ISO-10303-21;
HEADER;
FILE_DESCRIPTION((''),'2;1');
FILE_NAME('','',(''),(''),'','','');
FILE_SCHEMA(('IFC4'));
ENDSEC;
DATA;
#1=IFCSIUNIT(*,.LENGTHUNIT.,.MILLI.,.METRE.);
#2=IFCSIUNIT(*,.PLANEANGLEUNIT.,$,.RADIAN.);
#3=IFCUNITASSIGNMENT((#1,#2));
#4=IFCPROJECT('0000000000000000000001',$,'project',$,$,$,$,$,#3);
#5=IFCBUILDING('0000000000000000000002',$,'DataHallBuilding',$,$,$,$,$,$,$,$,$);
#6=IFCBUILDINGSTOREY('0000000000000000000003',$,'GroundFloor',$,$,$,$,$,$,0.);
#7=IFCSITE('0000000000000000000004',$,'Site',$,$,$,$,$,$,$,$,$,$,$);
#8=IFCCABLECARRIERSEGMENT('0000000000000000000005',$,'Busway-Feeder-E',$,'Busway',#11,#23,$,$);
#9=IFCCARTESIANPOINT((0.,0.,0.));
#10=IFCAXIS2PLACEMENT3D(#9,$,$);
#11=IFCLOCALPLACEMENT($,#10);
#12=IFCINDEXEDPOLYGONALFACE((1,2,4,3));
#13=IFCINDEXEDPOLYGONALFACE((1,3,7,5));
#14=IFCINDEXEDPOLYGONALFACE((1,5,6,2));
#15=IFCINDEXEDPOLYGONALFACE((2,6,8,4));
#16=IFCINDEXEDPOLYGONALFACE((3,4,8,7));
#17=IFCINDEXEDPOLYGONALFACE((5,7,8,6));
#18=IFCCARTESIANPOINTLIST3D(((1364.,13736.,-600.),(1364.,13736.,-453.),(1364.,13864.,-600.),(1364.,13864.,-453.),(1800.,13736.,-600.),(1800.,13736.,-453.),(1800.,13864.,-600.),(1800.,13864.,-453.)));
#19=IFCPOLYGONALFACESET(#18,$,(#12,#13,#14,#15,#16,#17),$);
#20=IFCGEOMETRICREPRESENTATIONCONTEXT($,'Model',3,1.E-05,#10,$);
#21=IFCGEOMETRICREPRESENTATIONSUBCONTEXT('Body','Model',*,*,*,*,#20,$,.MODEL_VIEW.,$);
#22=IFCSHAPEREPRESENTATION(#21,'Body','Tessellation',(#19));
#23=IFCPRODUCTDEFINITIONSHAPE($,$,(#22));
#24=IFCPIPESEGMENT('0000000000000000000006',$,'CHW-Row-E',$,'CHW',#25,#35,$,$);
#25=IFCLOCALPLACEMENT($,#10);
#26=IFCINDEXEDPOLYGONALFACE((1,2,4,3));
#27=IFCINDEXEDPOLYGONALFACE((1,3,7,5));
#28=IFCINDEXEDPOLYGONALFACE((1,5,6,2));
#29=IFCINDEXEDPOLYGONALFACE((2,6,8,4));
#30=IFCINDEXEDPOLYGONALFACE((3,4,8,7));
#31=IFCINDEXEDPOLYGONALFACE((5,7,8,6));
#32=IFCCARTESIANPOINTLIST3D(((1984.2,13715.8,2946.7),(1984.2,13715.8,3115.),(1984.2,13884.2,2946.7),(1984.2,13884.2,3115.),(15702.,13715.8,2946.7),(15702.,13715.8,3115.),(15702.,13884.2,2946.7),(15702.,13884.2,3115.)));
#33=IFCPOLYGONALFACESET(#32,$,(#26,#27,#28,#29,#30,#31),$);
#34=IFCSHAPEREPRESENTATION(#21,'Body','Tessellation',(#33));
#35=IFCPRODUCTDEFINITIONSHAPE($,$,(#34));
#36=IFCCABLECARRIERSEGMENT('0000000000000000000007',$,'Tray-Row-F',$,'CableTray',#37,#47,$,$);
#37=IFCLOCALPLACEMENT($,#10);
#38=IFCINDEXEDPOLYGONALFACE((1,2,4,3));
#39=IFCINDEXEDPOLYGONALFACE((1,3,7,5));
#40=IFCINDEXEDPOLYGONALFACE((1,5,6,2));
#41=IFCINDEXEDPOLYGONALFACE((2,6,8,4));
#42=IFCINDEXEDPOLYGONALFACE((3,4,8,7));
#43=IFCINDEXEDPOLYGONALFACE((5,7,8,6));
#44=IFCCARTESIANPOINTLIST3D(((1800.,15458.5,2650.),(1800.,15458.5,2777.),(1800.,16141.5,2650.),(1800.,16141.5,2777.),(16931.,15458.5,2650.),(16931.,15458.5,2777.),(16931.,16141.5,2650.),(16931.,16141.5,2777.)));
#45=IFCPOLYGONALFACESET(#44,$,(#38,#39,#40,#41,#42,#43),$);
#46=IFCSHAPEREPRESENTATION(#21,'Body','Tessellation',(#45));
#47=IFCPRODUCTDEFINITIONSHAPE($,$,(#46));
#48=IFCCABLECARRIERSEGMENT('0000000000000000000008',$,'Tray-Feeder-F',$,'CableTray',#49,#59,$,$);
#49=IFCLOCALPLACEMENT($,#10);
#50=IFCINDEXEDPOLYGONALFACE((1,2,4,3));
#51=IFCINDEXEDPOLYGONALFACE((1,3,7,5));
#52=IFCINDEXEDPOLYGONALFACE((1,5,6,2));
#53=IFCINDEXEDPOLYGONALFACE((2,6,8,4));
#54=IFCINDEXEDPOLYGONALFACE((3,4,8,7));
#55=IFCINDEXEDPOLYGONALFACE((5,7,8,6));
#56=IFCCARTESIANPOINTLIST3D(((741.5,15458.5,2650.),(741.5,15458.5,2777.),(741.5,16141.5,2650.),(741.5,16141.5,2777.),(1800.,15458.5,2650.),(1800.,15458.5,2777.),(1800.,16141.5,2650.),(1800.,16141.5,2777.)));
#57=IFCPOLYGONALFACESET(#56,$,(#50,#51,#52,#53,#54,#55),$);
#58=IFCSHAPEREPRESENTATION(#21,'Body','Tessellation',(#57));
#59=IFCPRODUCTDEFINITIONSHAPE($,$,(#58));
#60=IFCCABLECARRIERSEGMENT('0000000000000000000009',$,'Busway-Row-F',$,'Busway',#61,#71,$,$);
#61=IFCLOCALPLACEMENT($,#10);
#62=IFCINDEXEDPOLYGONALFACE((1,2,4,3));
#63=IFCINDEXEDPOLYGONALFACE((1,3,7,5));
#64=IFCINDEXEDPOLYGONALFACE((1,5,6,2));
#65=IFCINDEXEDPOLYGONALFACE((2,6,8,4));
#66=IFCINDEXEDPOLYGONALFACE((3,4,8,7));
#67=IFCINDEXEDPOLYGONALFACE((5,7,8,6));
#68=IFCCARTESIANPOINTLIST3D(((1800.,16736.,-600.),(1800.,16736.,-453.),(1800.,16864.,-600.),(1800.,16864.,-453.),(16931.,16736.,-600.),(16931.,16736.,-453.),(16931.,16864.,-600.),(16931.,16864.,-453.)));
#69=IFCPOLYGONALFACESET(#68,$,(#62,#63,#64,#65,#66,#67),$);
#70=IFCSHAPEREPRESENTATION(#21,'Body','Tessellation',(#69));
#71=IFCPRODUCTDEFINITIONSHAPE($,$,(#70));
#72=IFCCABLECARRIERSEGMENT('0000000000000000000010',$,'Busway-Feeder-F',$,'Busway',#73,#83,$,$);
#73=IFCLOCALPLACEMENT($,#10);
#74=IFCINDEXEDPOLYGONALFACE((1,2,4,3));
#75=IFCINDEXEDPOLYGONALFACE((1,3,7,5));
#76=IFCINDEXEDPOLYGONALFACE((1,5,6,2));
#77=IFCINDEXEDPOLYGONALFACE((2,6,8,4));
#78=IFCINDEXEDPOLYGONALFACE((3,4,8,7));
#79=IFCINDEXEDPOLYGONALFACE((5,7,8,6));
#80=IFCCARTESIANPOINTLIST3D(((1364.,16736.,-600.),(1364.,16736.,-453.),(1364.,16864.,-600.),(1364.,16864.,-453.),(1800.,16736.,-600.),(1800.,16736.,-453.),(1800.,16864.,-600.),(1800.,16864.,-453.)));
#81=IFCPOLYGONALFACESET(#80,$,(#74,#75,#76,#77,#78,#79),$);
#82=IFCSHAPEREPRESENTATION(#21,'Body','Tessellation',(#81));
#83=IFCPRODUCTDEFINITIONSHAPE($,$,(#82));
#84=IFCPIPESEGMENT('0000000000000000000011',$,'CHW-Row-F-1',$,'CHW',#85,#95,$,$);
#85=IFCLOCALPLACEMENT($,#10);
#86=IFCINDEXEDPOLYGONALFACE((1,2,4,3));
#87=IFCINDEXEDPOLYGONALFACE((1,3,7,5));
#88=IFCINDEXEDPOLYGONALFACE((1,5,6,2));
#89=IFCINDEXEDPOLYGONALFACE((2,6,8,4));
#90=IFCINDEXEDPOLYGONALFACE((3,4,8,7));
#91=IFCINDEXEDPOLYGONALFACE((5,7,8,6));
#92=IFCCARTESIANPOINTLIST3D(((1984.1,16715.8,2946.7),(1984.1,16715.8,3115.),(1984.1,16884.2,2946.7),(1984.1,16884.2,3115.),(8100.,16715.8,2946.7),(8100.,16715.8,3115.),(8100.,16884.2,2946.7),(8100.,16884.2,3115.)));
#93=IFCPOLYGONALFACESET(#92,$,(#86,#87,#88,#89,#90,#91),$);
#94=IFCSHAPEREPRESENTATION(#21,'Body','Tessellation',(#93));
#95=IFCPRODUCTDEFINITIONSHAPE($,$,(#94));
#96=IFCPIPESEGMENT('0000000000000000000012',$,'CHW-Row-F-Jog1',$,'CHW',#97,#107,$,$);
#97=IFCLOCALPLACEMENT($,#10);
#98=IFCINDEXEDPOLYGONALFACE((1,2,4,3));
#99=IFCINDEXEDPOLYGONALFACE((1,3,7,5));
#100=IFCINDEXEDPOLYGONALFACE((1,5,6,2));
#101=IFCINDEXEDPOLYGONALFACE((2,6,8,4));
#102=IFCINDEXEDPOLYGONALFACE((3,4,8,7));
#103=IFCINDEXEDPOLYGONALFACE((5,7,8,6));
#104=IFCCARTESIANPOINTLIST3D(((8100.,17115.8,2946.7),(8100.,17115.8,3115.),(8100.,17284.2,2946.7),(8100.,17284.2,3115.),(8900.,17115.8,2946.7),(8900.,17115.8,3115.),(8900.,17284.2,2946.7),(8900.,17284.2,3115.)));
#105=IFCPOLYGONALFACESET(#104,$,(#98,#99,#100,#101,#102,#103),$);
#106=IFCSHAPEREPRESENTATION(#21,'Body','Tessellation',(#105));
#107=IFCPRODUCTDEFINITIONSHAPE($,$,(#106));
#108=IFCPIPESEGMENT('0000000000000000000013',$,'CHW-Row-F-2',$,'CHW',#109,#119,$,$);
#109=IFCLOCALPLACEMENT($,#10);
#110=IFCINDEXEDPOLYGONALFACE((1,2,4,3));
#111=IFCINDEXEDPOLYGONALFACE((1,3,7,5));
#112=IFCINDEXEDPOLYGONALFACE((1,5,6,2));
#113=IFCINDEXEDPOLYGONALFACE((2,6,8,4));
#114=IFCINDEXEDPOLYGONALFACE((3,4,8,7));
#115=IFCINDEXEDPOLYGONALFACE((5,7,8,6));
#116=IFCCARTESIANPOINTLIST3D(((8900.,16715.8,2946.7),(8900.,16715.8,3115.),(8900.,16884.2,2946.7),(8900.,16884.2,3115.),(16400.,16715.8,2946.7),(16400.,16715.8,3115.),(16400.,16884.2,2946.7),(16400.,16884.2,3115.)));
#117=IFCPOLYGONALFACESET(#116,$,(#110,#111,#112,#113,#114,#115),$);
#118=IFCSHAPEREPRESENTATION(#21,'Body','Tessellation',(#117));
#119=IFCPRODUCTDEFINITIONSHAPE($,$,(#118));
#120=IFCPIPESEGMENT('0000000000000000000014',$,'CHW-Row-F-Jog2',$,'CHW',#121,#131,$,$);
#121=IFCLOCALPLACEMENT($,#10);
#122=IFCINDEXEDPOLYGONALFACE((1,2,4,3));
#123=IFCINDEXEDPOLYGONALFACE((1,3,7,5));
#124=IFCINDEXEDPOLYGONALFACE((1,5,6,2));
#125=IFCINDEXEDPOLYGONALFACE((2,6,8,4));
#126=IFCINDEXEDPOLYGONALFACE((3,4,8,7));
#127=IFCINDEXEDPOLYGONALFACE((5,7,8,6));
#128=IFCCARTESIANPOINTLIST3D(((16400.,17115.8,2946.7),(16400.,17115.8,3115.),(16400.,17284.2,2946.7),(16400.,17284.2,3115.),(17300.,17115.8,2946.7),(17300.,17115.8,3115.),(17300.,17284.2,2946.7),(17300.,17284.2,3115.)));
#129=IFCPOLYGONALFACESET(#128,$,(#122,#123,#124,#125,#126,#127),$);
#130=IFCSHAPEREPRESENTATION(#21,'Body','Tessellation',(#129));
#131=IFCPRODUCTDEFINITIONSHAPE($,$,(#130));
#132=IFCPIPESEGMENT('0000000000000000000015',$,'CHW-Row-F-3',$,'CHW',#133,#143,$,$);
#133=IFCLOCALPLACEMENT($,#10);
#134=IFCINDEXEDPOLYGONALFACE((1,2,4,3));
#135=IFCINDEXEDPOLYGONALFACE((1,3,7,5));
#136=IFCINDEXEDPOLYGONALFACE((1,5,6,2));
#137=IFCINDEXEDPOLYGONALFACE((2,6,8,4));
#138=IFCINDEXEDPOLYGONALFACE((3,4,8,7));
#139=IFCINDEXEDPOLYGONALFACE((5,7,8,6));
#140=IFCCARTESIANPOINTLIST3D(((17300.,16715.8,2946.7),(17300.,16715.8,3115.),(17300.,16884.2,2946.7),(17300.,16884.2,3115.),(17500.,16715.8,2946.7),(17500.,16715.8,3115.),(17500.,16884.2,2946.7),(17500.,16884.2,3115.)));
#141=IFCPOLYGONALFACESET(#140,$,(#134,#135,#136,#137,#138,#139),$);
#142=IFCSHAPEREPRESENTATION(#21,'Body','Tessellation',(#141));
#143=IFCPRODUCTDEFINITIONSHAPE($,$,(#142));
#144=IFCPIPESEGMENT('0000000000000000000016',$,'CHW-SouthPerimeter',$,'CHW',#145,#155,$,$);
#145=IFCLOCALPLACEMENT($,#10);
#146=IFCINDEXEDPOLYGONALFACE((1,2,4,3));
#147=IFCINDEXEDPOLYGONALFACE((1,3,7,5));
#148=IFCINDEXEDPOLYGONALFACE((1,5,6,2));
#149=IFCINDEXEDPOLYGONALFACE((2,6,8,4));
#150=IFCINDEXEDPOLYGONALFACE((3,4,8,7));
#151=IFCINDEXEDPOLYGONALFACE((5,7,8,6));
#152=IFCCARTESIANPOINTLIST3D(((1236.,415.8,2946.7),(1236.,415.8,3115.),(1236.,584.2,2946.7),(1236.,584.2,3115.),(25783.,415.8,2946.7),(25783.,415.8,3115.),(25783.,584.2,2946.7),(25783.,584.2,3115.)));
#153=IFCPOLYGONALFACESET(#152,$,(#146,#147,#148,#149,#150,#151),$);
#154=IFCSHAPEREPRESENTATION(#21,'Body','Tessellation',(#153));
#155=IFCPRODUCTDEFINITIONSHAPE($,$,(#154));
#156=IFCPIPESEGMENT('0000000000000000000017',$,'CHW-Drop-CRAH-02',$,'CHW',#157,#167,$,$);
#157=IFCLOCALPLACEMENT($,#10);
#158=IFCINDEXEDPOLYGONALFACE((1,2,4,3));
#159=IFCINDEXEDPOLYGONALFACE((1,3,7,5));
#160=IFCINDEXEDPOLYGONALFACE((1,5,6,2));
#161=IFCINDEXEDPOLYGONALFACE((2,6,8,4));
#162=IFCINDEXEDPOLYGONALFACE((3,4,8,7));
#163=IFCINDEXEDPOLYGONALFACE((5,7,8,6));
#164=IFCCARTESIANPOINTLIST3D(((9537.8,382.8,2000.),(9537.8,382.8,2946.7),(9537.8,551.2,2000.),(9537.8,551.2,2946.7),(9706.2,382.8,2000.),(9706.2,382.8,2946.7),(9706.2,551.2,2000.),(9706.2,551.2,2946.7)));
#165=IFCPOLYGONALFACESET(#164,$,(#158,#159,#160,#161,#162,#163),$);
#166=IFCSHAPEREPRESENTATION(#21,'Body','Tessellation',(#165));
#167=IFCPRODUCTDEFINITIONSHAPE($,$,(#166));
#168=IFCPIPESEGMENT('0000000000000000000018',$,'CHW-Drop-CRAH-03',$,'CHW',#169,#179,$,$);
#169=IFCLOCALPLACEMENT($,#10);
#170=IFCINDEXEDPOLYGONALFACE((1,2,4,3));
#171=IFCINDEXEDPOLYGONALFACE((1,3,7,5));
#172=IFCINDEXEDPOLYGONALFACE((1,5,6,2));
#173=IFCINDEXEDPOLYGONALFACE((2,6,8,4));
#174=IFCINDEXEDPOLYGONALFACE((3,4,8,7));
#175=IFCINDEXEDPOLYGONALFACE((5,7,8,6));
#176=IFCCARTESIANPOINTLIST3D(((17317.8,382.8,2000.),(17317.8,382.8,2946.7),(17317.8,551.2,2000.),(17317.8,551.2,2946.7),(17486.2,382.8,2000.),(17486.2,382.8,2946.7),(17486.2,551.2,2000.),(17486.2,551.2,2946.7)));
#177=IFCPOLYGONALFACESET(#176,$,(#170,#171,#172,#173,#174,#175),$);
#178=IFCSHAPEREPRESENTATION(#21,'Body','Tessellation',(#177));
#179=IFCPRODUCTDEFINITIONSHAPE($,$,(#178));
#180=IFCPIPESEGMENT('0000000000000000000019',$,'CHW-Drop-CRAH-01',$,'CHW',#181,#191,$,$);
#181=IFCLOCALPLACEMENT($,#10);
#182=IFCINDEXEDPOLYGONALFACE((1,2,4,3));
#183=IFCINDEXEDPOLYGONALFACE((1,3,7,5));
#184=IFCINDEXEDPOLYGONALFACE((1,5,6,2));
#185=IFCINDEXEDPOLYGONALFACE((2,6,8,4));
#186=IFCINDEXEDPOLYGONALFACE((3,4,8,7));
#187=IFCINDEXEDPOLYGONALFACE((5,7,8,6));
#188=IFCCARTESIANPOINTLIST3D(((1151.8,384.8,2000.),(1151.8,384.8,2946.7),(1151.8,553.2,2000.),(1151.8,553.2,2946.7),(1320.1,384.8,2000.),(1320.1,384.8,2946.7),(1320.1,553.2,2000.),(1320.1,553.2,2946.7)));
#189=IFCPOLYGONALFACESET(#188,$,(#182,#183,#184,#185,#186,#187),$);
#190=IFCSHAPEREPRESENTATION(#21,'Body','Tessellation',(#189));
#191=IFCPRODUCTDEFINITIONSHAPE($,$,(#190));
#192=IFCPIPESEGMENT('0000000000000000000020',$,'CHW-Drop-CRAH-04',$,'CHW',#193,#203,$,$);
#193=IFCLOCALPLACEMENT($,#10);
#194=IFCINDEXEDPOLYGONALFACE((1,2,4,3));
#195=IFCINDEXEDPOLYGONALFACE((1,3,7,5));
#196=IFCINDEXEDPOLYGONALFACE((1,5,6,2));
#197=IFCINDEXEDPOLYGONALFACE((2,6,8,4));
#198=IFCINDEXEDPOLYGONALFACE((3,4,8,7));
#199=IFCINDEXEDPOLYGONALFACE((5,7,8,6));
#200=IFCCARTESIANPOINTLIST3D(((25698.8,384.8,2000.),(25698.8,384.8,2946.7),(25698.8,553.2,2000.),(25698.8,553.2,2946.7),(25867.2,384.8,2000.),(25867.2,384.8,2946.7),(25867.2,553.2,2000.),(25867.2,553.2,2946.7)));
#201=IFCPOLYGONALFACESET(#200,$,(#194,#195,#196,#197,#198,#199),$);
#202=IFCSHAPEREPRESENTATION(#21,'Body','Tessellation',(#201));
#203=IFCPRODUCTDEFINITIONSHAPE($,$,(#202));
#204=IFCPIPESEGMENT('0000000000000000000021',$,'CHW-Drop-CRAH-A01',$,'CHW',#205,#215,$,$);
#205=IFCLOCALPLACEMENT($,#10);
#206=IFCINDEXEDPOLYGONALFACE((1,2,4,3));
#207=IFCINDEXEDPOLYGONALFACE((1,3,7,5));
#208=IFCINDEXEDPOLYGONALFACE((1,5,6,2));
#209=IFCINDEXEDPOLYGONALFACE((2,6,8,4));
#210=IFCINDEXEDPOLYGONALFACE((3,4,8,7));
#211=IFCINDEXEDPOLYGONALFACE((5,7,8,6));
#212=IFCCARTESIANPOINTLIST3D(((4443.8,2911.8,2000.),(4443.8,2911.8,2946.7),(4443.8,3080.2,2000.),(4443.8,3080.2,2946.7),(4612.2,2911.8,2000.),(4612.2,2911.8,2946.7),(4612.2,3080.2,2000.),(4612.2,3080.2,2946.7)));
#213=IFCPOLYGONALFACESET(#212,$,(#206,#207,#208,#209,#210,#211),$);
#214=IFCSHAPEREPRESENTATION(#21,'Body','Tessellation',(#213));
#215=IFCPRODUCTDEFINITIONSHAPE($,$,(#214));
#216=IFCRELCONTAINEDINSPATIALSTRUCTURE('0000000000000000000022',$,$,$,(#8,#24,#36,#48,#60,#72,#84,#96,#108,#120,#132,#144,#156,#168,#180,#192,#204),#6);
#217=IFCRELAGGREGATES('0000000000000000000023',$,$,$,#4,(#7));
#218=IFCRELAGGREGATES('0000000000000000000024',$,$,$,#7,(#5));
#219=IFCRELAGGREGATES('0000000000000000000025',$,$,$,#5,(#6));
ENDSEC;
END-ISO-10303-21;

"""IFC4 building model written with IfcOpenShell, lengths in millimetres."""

from ifc_helpers import new_model, si_unit, frame, origin, place, context, subcontext, project, spatial, rectangle, extrude, element, save


model = new_model("IFC4")

# Units and contexts
model_context = context("Model", 3, precision=1e-05, world=origin())
body_context = subcontext(model_context, "Body", "Model", "MODEL_VIEW")
ifc_project = project(units=[si_unit("LENGTHUNIT", "METRE", prefix="MILLI"), si_unit("PLANEANGLEUNIT", "RADIAN")])

# Site, building, storey
site = spatial("IfcSite", under=ifc_project, Name="Site")
building = spatial("IfcBuilding", under=site, Name="DataHallBuilding")
storey = spatial("IfcBuildingStorey", under=building, Name="GroundFloor", Elevation=0.0)

# Cable carrier segment
cable_carrier_segment_1_placement = place(None, origin())
element("IfcCableCarrierSegment", 1, at=cable_carrier_segment_1_placement, inside=storey, Name="Busway-Feeder-E", ObjectType="Busway", context=body_context, shape_type="SweptSolid", body=[
    extrude(rectangle(XDim=436.0, YDim=128.0), frame((1582.0, 13800.0, -600.0), z_axis=(0.0, 0.0, 1.0), x_axis=(1.0, 0.0, 0.0)), (0.0, 0.0, 1.0), 147.0),
])

# Pipe segment
pipe_segment_1_placement = place(None, origin())
element("IfcPipeSegment", 2, at=pipe_segment_1_placement, inside=storey, Name="CHW-Row-E", ObjectType="CHW", context=body_context, shape_type="SweptSolid", body=[
    extrude(rectangle(XDim=13717.9, YDim=168.3), frame((8843.1, 13800.0, 2946.7), z_axis=(0.0, 0.0, 1.0), x_axis=(1.0, 0.0, 0.0)), (0.0, 0.0, 1.0), 168.3),
])

# Cable carrier segments
cable_carrier_segment_2_placement = place(None, origin())
element("IfcCableCarrierSegment", 3, at=cable_carrier_segment_2_placement, inside=storey, Name="Tray-Row-F", ObjectType="CableTray", context=body_context, shape_type="SweptSolid", body=[
    extrude(rectangle(XDim=15131.0, YDim=683.0), frame((9365.5, 15800.0, 2650.0), z_axis=(0.0, 0.0, 1.0), x_axis=(1.0, 0.0, 0.0)), (0.0, 0.0, 1.0), 127.0),
])
cable_carrier_segment_3_placement = place(None, origin())
element("IfcCableCarrierSegment", 4, at=cable_carrier_segment_3_placement, inside=storey, Name="Tray-Feeder-F", ObjectType="CableTray", context=body_context, shape_type="SweptSolid", body=[
    extrude(rectangle(XDim=1058.5, YDim=683.0), frame((1270.8, 15800.0, 2650.0), z_axis=(0.0, 0.0, 1.0), x_axis=(1.0, 0.0, 0.0)), (0.0, 0.0, 1.0), 127.0),
])
cable_carrier_segment_4_placement = place(None, origin())
element("IfcCableCarrierSegment", 5, at=cable_carrier_segment_4_placement, inside=storey, Name="Busway-Row-F", ObjectType="Busway", context=body_context, shape_type="SweptSolid", body=[
    extrude(rectangle(XDim=15131.0, YDim=128.0), frame((9365.5, 16800.0, -600.0), z_axis=(0.0, 0.0, 1.0), x_axis=(1.0, 0.0, 0.0)), (0.0, 0.0, 1.0), 147.0),
])
cable_carrier_segment_5_placement = place(None, origin())
element("IfcCableCarrierSegment", 6, at=cable_carrier_segment_5_placement, inside=storey, Name="Busway-Feeder-F", ObjectType="Busway", context=body_context, shape_type="SweptSolid", body=[
    extrude(rectangle(XDim=436.0, YDim=128.0), frame((1582.0, 16800.0, -600.0), z_axis=(0.0, 0.0, 1.0), x_axis=(1.0, 0.0, 0.0)), (0.0, 0.0, 1.0), 147.0),
])

# Pipe segments
pipe_segment_2_placement = place(None, origin())
element("IfcPipeSegment", 7, at=pipe_segment_2_placement, inside=storey, Name="CHW-Row-F-1", ObjectType="CHW", context=body_context, shape_type="SweptSolid", body=[
    extrude(rectangle(XDim=6115.9, YDim=168.3), frame((5042.1, 16800.0, 2946.7), z_axis=(0.0, 0.0, 1.0), x_axis=(1.0, 0.0, 0.0)), (0.0, 0.0, 1.0), 168.3),
])
pipe_segment_3_placement = place(None, origin())
element("IfcPipeSegment", 8, at=pipe_segment_3_placement, inside=storey, Name="CHW-Row-F-Jog1", ObjectType="CHW", context=body_context, shape_type="SweptSolid", body=[
    extrude(rectangle(XDim=800.0, YDim=168.3), frame((8500.0, 17200.0, 2946.7), z_axis=(0.0, 0.0, 1.0), x_axis=(1.0, 0.0, 0.0)), (0.0, 0.0, 1.0), 168.3),
])
pipe_segment_4_placement = place(None, origin())
element("IfcPipeSegment", 9, at=pipe_segment_4_placement, inside=storey, Name="CHW-Row-F-2", ObjectType="CHW", context=body_context, shape_type="SweptSolid", body=[
    extrude(rectangle(XDim=7500.0, YDim=168.3), frame((12650.0, 16800.0, 2946.7), z_axis=(0.0, 0.0, 1.0), x_axis=(1.0, 0.0, 0.0)), (0.0, 0.0, 1.0), 168.3),
])
pipe_segment_5_placement = place(None, origin())
element("IfcPipeSegment", 10, at=pipe_segment_5_placement, inside=storey, Name="CHW-Row-F-Jog2", ObjectType="CHW", context=body_context, shape_type="SweptSolid", body=[
    extrude(rectangle(XDim=900.0, YDim=168.3), frame((16850.0, 17200.0, 2946.7), z_axis=(0.0, 0.0, 1.0), x_axis=(1.0, 0.0, 0.0)), (0.0, 0.0, 1.0), 168.3),
])
pipe_segment_6_placement = place(None, origin())
element("IfcPipeSegment", 11, at=pipe_segment_6_placement, inside=storey, Name="CHW-Row-F-3", ObjectType="CHW", context=body_context, shape_type="SweptSolid", body=[
    extrude(rectangle(XDim=200.0, YDim=168.3), frame((17400.0, 16800.0, 2946.7), z_axis=(0.0, 0.0, 1.0), x_axis=(1.0, 0.0, 0.0)), (0.0, 0.0, 1.0), 168.3),
])
pipe_segment_7_placement = place(None, origin())
element("IfcPipeSegment", 12, at=pipe_segment_7_placement, inside=storey, Name="CHW-SouthPerimeter", ObjectType="CHW", context=body_context, shape_type="SweptSolid", body=[
    extrude(rectangle(XDim=24547.0, YDim=168.3), frame((13509.5, 500.0, 2946.7), z_axis=(0.0, 0.0, 1.0), x_axis=(1.0, 0.0, 0.0)), (0.0, 0.0, 1.0), 168.3),
])
pipe_segment_8_placement = place(None, origin())
element("IfcPipeSegment", 13, at=pipe_segment_8_placement, inside=storey, Name="CHW-Drop-CRAH-02", ObjectType="CHW", context=body_context, shape_type="SweptSolid", body=[
    extrude(rectangle(XDim=168.3, YDim=168.3), frame((9622.0, 467.0, 2000.0), z_axis=(0.0, 0.0, 1.0), x_axis=(1.0, 0.0, 0.0)), (0.0, 0.0, 1.0), 946.7),
])
pipe_segment_9_placement = place(None, origin())
element("IfcPipeSegment", 14, at=pipe_segment_9_placement, inside=storey, Name="CHW-Drop-CRAH-03", ObjectType="CHW", context=body_context, shape_type="SweptSolid", body=[
    extrude(rectangle(XDim=168.3, YDim=168.3), frame((17402.0, 467.0, 2000.0), z_axis=(0.0, 0.0, 1.0), x_axis=(1.0, 0.0, 0.0)), (0.0, 0.0, 1.0), 946.7),
])
pipe_segment_10_placement = place(None, origin())
element("IfcPipeSegment", 15, at=pipe_segment_10_placement, inside=storey, Name="CHW-Drop-CRAH-01", ObjectType="CHW", context=body_context, shape_type="SweptSolid", body=[
    extrude(rectangle(XDim=168.3, YDim=168.3), frame((1236.0, 469.0, 2000.0), z_axis=(0.0, 0.0, 1.0), x_axis=(1.0, 0.0, 0.0)), (0.0, 0.0, 1.0), 946.7),
])
pipe_segment_11_placement = place(None, origin())
element("IfcPipeSegment", 16, at=pipe_segment_11_placement, inside=storey, Name="CHW-Drop-CRAH-04", ObjectType="CHW", context=body_context, shape_type="SweptSolid", body=[
    extrude(rectangle(XDim=168.3, YDim=168.3), frame((25783.0, 469.0, 2000.0), z_axis=(0.0, 0.0, 1.0), x_axis=(1.0, 0.0, 0.0)), (0.0, 0.0, 1.0), 946.7),
])
pipe_segment_12_placement = place(None, origin())
element("IfcPipeSegment", 17, at=pipe_segment_12_placement, inside=storey, Name="CHW-Drop-CRAH-A01", ObjectType="CHW", context=body_context, shape_type="SweptSolid", body=[
    extrude(rectangle(XDim=168.3, YDim=168.3), frame((4528.0, 2996.0, 2000.0), z_axis=(0.0, 0.0, 1.0), x_axis=(1.0, 0.0, 0.0)), (0.0, 0.0, 1.0), 946.7),
])

save(model, "model.ifc")
